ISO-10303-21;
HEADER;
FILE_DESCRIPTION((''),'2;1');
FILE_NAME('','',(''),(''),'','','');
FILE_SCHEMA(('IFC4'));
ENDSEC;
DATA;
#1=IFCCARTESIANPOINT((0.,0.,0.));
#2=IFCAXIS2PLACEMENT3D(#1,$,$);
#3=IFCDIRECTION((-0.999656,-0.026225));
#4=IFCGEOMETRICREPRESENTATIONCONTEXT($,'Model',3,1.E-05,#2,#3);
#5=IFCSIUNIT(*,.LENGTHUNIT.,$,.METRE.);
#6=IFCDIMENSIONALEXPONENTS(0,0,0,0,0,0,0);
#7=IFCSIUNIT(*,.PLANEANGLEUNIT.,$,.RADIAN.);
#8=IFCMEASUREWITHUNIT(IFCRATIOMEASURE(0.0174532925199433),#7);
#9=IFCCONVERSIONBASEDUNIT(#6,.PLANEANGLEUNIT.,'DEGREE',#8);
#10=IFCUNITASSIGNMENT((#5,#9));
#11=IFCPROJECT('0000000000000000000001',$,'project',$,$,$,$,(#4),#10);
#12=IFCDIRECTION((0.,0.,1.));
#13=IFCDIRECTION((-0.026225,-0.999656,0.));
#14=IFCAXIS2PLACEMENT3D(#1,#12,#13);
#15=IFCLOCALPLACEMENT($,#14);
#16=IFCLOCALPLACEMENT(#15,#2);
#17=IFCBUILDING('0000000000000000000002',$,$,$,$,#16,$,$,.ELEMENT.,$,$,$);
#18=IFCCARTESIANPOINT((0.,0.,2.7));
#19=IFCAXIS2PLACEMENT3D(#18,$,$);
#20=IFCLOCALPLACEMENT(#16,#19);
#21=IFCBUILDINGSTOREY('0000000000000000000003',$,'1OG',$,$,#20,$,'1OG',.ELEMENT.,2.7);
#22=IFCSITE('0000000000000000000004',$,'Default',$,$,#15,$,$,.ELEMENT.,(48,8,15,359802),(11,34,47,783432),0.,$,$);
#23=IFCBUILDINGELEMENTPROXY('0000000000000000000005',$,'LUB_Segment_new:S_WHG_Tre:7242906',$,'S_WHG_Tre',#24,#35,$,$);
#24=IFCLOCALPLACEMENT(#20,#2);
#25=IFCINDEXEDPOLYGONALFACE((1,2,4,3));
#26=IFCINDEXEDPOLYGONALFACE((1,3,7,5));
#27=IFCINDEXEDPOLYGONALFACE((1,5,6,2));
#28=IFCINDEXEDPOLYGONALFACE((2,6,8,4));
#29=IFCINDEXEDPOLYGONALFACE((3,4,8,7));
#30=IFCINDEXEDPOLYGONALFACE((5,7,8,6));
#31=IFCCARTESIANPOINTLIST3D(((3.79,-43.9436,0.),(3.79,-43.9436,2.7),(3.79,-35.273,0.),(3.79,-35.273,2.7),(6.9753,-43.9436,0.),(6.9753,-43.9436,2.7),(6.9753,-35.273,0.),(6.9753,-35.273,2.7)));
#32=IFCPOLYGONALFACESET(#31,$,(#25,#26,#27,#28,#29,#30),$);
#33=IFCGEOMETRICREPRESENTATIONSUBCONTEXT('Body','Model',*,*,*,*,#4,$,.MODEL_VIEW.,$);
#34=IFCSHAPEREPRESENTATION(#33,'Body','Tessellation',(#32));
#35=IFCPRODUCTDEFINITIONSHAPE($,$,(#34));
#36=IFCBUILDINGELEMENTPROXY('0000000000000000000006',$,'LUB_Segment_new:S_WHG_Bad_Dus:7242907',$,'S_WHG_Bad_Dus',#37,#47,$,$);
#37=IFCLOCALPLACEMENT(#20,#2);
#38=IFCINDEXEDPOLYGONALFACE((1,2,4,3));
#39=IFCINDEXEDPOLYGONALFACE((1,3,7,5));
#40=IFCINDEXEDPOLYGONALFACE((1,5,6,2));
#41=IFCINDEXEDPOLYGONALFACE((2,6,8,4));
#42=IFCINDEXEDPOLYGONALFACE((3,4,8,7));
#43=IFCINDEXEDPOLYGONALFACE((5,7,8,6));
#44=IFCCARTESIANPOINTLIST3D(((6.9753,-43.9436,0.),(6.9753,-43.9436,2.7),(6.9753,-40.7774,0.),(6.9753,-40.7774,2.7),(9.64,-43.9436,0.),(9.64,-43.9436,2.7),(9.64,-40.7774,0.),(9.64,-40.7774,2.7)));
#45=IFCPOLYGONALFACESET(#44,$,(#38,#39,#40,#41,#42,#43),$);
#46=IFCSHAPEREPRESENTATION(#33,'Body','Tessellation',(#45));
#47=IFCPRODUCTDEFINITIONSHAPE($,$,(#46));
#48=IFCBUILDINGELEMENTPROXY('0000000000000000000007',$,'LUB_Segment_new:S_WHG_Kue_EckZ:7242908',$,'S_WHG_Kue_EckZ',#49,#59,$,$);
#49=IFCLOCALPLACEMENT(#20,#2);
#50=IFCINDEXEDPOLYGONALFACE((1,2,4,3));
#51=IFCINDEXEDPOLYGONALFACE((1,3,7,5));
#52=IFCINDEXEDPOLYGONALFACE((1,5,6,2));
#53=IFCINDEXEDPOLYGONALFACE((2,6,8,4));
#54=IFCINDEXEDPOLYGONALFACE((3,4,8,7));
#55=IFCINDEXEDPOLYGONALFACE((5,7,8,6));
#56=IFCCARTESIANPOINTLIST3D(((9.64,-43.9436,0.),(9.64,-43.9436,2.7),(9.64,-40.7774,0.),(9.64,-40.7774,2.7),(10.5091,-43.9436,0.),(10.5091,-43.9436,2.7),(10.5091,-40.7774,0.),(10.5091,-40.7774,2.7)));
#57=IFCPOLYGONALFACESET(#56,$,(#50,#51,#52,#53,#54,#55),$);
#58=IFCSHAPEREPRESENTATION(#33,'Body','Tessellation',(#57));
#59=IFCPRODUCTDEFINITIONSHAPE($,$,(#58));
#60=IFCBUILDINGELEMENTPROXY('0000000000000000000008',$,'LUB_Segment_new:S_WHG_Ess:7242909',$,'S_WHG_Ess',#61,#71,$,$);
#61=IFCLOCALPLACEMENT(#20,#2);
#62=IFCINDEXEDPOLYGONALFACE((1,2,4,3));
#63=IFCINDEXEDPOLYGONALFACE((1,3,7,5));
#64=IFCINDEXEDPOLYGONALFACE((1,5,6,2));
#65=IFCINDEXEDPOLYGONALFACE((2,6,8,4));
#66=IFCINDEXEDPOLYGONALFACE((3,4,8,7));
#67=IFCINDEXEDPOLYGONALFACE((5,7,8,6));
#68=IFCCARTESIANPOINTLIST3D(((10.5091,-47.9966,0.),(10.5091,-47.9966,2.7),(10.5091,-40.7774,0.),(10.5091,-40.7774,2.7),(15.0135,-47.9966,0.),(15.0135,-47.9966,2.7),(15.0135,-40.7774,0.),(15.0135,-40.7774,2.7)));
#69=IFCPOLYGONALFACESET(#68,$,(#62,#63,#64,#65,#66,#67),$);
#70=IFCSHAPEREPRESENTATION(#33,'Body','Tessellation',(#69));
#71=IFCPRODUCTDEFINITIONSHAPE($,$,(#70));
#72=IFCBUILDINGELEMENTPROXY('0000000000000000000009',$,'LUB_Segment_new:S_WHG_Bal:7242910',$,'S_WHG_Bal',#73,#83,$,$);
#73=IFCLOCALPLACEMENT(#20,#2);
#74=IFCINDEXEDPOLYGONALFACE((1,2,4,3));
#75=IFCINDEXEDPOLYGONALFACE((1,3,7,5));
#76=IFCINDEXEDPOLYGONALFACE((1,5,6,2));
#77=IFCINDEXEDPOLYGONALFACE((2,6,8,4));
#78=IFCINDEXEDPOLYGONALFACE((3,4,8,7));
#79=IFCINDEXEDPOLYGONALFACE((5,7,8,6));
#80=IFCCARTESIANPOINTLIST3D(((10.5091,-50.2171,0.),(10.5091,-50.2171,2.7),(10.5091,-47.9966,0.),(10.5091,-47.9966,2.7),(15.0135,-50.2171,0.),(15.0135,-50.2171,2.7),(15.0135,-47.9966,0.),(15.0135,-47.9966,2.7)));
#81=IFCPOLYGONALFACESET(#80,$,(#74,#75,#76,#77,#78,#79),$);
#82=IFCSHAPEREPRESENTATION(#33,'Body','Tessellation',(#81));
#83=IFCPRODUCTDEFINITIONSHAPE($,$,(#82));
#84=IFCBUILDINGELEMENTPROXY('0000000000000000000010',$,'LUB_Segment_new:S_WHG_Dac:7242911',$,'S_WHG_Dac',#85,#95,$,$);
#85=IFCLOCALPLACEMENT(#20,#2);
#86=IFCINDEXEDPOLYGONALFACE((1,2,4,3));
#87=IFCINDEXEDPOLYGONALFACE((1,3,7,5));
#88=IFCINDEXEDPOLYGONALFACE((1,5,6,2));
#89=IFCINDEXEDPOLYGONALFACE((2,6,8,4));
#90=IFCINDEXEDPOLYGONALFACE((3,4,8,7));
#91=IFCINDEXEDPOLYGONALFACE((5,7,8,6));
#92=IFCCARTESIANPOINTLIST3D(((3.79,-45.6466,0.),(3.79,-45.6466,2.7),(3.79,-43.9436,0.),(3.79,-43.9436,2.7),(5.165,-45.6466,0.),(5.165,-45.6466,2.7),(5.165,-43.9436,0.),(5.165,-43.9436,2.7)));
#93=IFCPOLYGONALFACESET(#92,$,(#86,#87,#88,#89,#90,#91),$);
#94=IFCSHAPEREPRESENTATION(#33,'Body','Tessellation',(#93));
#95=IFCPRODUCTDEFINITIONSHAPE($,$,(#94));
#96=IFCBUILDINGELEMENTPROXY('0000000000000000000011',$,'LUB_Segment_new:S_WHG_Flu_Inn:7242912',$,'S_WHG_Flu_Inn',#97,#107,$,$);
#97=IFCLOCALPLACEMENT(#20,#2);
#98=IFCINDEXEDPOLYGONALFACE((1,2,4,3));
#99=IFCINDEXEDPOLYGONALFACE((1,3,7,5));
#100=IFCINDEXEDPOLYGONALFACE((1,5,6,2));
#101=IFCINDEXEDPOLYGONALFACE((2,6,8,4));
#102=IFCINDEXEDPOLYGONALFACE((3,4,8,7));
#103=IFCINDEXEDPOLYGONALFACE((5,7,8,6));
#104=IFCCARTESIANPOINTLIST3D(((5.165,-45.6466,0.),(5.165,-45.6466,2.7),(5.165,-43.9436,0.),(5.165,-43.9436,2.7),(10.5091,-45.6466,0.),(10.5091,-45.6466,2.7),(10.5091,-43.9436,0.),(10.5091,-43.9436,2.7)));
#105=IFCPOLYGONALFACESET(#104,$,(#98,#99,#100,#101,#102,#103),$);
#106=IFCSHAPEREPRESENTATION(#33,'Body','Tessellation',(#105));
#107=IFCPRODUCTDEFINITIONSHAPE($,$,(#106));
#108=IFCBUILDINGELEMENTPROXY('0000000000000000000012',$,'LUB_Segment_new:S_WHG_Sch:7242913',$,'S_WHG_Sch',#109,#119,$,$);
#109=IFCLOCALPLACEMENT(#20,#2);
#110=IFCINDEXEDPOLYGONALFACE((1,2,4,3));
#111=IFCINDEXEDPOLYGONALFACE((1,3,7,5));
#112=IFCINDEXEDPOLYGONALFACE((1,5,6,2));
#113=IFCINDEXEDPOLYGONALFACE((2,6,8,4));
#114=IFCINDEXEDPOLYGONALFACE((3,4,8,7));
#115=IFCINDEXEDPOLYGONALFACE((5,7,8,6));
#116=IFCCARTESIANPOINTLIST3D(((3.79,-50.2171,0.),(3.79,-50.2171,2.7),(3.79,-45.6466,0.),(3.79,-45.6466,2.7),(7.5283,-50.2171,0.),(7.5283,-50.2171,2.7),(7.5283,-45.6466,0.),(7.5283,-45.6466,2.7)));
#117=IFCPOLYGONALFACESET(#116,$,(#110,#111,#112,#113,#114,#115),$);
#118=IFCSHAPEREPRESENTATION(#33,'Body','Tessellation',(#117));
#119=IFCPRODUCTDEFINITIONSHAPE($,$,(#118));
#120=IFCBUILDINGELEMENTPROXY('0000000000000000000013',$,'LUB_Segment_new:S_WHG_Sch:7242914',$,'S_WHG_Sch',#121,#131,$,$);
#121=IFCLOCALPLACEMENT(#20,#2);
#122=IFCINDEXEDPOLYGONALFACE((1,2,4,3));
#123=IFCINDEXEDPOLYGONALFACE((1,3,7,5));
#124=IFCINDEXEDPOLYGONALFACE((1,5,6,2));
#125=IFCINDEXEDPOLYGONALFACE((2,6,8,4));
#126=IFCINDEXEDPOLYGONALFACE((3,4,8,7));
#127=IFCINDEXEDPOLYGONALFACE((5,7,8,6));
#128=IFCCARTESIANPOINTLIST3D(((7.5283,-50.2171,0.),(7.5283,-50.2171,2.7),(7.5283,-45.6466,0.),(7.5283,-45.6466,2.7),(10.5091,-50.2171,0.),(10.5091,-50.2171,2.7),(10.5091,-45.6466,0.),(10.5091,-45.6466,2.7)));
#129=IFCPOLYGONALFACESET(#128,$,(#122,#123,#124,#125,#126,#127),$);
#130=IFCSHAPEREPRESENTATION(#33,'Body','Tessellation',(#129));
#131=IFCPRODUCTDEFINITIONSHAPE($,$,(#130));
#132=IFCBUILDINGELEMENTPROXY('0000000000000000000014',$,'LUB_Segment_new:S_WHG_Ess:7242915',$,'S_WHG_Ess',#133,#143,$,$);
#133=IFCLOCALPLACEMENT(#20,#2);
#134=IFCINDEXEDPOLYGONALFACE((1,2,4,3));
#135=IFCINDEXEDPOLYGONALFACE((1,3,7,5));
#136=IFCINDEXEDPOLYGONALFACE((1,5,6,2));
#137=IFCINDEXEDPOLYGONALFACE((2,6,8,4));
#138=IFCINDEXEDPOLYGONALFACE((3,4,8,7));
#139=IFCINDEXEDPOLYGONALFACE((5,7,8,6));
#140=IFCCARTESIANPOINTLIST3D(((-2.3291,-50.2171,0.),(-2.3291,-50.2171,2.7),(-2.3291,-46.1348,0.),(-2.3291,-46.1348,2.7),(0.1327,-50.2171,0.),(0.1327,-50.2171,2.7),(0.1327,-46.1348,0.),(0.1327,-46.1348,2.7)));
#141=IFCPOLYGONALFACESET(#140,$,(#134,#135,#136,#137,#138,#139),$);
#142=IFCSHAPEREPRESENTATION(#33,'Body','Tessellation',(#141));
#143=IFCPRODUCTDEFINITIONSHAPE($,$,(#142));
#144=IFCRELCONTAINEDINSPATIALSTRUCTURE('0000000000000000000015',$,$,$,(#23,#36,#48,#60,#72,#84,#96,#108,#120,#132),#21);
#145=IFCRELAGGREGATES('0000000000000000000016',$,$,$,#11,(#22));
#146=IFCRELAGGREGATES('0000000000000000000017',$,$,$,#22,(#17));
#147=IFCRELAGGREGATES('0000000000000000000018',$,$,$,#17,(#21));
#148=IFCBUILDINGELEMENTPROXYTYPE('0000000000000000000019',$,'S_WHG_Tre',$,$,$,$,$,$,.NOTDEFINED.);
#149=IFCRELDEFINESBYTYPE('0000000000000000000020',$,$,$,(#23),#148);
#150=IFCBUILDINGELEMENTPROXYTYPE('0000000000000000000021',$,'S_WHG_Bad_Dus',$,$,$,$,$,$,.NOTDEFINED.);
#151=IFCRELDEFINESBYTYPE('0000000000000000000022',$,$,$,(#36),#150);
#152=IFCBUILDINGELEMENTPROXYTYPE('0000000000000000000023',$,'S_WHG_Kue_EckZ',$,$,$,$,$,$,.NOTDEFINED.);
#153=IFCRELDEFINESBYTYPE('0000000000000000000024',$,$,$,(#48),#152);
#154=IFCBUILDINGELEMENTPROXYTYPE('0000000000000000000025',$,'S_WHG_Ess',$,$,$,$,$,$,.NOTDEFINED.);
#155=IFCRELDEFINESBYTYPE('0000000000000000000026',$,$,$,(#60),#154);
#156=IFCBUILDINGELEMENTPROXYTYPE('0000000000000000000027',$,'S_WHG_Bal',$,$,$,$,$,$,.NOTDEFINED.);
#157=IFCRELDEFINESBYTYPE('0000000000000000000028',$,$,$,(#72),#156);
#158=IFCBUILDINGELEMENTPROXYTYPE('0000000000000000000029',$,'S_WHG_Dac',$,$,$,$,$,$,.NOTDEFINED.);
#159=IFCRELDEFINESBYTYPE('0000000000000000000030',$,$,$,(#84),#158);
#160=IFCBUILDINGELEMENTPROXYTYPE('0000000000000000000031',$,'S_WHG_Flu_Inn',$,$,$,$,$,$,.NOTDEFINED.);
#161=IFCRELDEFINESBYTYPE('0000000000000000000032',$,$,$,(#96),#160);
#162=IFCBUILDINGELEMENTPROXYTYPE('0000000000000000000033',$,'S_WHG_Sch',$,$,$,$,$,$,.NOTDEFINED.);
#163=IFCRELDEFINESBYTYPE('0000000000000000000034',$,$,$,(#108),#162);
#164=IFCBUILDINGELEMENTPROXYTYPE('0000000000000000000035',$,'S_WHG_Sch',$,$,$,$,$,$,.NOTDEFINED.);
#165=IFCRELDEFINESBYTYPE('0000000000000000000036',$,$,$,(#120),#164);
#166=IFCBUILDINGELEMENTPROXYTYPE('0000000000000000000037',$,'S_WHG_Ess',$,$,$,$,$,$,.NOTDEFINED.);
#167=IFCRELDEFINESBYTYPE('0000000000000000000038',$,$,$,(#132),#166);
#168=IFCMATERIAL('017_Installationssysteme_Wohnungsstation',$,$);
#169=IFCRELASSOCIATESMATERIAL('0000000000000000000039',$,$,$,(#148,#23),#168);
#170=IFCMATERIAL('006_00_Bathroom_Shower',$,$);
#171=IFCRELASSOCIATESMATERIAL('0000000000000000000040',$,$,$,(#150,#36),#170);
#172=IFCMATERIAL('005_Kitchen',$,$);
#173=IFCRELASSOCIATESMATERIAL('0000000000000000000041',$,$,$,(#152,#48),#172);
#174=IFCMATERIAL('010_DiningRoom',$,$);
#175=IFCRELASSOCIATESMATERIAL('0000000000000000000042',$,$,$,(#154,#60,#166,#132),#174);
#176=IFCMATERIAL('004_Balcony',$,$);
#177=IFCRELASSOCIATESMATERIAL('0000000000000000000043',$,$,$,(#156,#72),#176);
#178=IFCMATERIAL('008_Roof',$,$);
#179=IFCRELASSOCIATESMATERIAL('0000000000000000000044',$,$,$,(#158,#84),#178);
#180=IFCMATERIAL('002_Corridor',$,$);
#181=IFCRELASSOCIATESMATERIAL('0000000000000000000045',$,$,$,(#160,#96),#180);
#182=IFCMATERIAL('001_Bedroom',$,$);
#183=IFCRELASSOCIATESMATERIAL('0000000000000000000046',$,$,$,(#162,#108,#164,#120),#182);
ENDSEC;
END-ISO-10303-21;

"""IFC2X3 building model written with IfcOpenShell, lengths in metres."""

from ifc_helpers import new_model, entity, si_unit, converted_unit, direction, frame, frame_2d, origin, origin_2d_with_axis, place, context, subcontext, project, spatial, rectangle, extrude, source, transform, mapped, material, type_object, type_shapes, element, save


model = new_model("IFC2X3")

# Units and contexts
model_context = context("Model", 3, precision=1e-05, world=origin(), true_north=direction((-0.999656, -0.026225)))
body_context = subcontext(model_context, "Body", "Model", "MODEL_VIEW")
ifc_project = project(units=[si_unit("LENGTHUNIT", "METRE"), converted_unit("PLANEANGLEUNIT", "DEGREE", entity("IfcRatioMeasure", 0.0174532925199433), si_unit("PLANEANGLEUNIT", "RADIAN"), dimensions=[0, 0, 0, 0, 0, 0, 0])], contexts=[model_context])

# Site, building, storey
site_placement = place(None, frame((0.0, 0.0, 0.0), z_axis=(0.0, 0.0, 1.0), x_axis=(-0.026225, -0.999656, 0.0)))
site = spatial("IfcSite", under=ifc_project, at=site_placement, Name="Default", CompositionType="ELEMENT", RefLatitude=(48, 8, 15, 359802), RefLongitude=(11, 34, 47, 783432), RefElevation=0.0)
building_placement = place(site_placement, origin())
building = spatial("IfcBuilding", under=site, at=building_placement, CompositionType="ELEMENT")
storey_placement = place(building_placement, frame((0.0, 0.0, 2.7)))
storey = spatial("IfcBuildingStorey", under=building, at=storey_placement, Name="1OG", LongName="1OG", CompositionType="ELEMENT", Elevation=2.7)

# Building element proxies
ifc_material_1 = material(Name="001_Bedroom")
ifc_material_2 = material(Name="010_DiningRoom")
ifc_material_3 = material(Name="004_Balcony")
ifc_material_4 = material(Name="005_Kitchen")
ifc_material_5 = material(Name="002_Corridor")
ifc_material_6 = material(Name="008_Roof")
ifc_material_7 = material(Name="006_00_Bathroom_Shower")
ifc_material_8 = material(Name="017_Installationssysteme_Wohnungsstation")
building_element_proxy_type_1 = type_object("IfcBuildingElementProxyType", Name="S_WHG_Tre", PredefinedType="NOTDEFINED", material=ifc_material_8)
shared_shape_1 = source(origin(), body_context, "Body", "SweptSolid", [
    extrude(rectangle(XDim=3.1853, YDim=8.6706, at=frame_2d((0.0, 0.0), x_axis=(1.0, 0.0))), frame((0.0, 0.0, 0.0), z_axis=(0.0, 0.0, 1.0), x_axis=(-1.0, 0.0, 0.0)), (0.0, 0.0, 1.0), 2.7),
])
type_shapes(building_element_proxy_type_1, [shared_shape_1])
proxy_1_placement = place(storey_placement, frame((5.3827, -39.6083, 0.0)))
element("IfcBuildingElementProxy", 1, at=proxy_1_placement, inside=storey, type_object=building_element_proxy_type_1, material=ifc_material_8, Name="LUB_Segment_new:S_WHG_Tre:7242906", ObjectType="S_WHG_Tre", context=body_context, shape_type="MappedRepresentation", body=[
    mapped(shared_shape_1, transform((0.0, 0.0, 0.0), scale=1.0)),
])
building_element_proxy_type_2 = type_object("IfcBuildingElementProxyType", Name="S_WHG_Bad_Dus", PredefinedType="NOTDEFINED", material=ifc_material_7)
shared_shape_2 = source(origin(), body_context, "Body", "SweptSolid", [
    extrude(rectangle(XDim=3.1662, YDim=2.6647, at=origin_2d_with_axis()), frame((0.0, 0.0, 0.0), z_axis=(0.0, 0.0, 1.0), x_axis=(0.0, 1.0, 0.0)), (0.0, 0.0, 1.0), 2.7),
])
type_shapes(building_element_proxy_type_2, [shared_shape_2])
proxy_2_placement = place(storey_placement, frame((8.3077, -42.3605, 0.0)))
element("IfcBuildingElementProxy", 2, at=proxy_2_placement, inside=storey, type_object=building_element_proxy_type_2, material=ifc_material_7, Name="LUB_Segment_new:S_WHG_Bad_Dus:7242907", ObjectType="S_WHG_Bad_Dus", context=body_context, shape_type="MappedRepresentation", body=[
    mapped(shared_shape_2, transform((0.0, 0.0, 0.0), scale=1.0)),
])
building_element_proxy_type_3 = type_object("IfcBuildingElementProxyType", Name="S_WHG_Kue_EckZ", PredefinedType="NOTDEFINED", material=ifc_material_4)
shared_shape_3 = source(origin(), body_context, "Body", "SweptSolid", [
    extrude(rectangle(XDim=3.1662, YDim=0.8691, at=origin_2d_with_axis()), frame((0.0, 0.0, 0.0), z_axis=(0.0, 0.0, 1.0), x_axis=(0.0, 1.0, 0.0)), (0.0, 0.0, 1.0), 2.7),
])
type_shapes(building_element_proxy_type_3, [shared_shape_3])
proxy_3_placement = place(storey_placement, frame((10.0746, -42.3605, 0.0)))
element("IfcBuildingElementProxy", 3, at=proxy_3_placement, inside=storey, type_object=building_element_proxy_type_3, material=ifc_material_4, Name="LUB_Segment_new:S_WHG_Kue_EckZ:7242908", ObjectType="S_WHG_Kue_EckZ", context=body_context, shape_type="MappedRepresentation", body=[
    mapped(shared_shape_3, transform((0.0, 0.0, 0.0), scale=1.0)),
])
building_element_proxy_type_4 = type_object("IfcBuildingElementProxyType", Name="S_WHG_Ess", PredefinedType="NOTDEFINED", material=ifc_material_2)
shared_shape_4 = source(origin(), body_context, "Body", "SweptSolid", [
    extrude(rectangle(XDim=4.5044, YDim=7.2191, at=origin_2d_with_axis()), frame((0.0, 0.0, 0.0), z_axis=(0.0, 0.0, 1.0), x_axis=(-1.0, 0.0, 0.0)), (0.0, 0.0, 1.0), 2.7),
])
type_shapes(building_element_proxy_type_4, [shared_shape_4])
proxy_4_placement = place(storey_placement, frame((12.7613, -44.387, 0.0)))
element("IfcBuildingElementProxy", 4, at=proxy_4_placement, inside=storey, type_object=building_element_proxy_type_4, material=ifc_material_2, Name="LUB_Segment_new:S_WHG_Ess:7242909", ObjectType="S_WHG_Ess", context=body_context, shape_type="MappedRepresentation", body=[
    mapped(shared_shape_4, transform((0.0, 0.0, 0.0), scale=1.0)),
])
building_element_proxy_type_5 = type_object("IfcBuildingElementProxyType", Name="S_WHG_Bal", PredefinedType="NOTDEFINED", material=ifc_material_3)
shared_shape_5 = source(origin(), body_context, "Body", "SweptSolid", [
    extrude(rectangle(XDim=2.2206, YDim=4.5044, at=origin_2d_with_axis()), frame((0.0, 0.0, 0.0), z_axis=(0.0, 0.0, 1.0), x_axis=(0.0, 1.0, 0.0)), (0.0, 0.0, 1.0), 2.7),
])
type_shapes(building_element_proxy_type_5, [shared_shape_5])
proxy_5_placement = place(storey_placement, frame((12.7613, -49.1068, 0.0)))
element("IfcBuildingElementProxy", 5, at=proxy_5_placement, inside=storey, type_object=building_element_proxy_type_5, material=ifc_material_3, Name="LUB_Segment_new:S_WHG_Bal:7242910", ObjectType="S_WHG_Bal", context=body_context, shape_type="MappedRepresentation", body=[
    mapped(shared_shape_5, transform((0.0, 0.0, 0.0), scale=1.0)),
])
building_element_proxy_type_6 = type_object("IfcBuildingElementProxyType", Name="S_WHG_Dac", PredefinedType="NOTDEFINED", material=ifc_material_6)
shared_shape_6 = source(origin(), body_context, "Body", "SweptSolid", [
    extrude(rectangle(XDim=1.7029, YDim=1.375, at=origin_2d_with_axis()), frame((0.0, 0.0, 0.0), z_axis=(0.0, 0.0, 1.0), x_axis=(0.0, 1.0, 0.0)), (0.0, 0.0, 1.0), 2.7),
])
type_shapes(building_element_proxy_type_6, [shared_shape_6])
proxy_6_placement = place(storey_placement, frame((4.4775, -44.7951, 0.0)))
element("IfcBuildingElementProxy", 6, at=proxy_6_placement, inside=storey, type_object=building_element_proxy_type_6, material=ifc_material_6, Name="LUB_Segment_new:S_WHG_Dac:7242911", ObjectType="S_WHG_Dac", context=body_context, shape_type="MappedRepresentation", body=[
    mapped(shared_shape_6, transform((0.0, 0.0, 0.0), scale=1.0)),
])
building_element_proxy_type_7 = type_object("IfcBuildingElementProxyType", Name="S_WHG_Flu_Inn", PredefinedType="NOTDEFINED", material=ifc_material_5)
shared_shape_7 = source(origin(), body_context, "Body", "SweptSolid", [
    extrude(rectangle(XDim=1.7029, YDim=5.3441, at=origin_2d_with_axis()), frame((0.0, 0.0, 0.0), z_axis=(0.0, 0.0, 1.0), x_axis=(0.0, 1.0, 0.0)), (0.0, 0.0, 1.0), 2.7),
])
type_shapes(building_element_proxy_type_7, [shared_shape_7])
proxy_7_placement = place(storey_placement, frame((7.8371, -44.7951, 0.0)))
element("IfcBuildingElementProxy", 7, at=proxy_7_placement, inside=storey, type_object=building_element_proxy_type_7, material=ifc_material_5, Name="LUB_Segment_new:S_WHG_Flu_Inn:7242912", ObjectType="S_WHG_Flu_Inn", context=body_context, shape_type="MappedRepresentation", body=[
    mapped(shared_shape_7, transform((0.0, 0.0, 0.0), scale=1.0)),
])
building_element_proxy_type_8 = type_object("IfcBuildingElementProxyType", Name="S_WHG_Sch", PredefinedType="NOTDEFINED", material=ifc_material_1)
shared_shape_8 = source(origin(), body_context, "Body", "SweptSolid", [
    extrude(rectangle(XDim=3.7382, YDim=4.5706, at=origin_2d_with_axis()), frame((0.0, 0.0, 0.0), z_axis=(0.0, 0.0, 1.0), x_axis=(-1.0, 0.0, 0.0)), (0.0, 0.0, 1.0), 2.7),
])
type_shapes(building_element_proxy_type_8, [shared_shape_8])
proxy_8_placement = place(storey_placement, frame((5.6591, -47.9318, 0.0)))
element("IfcBuildingElementProxy", 8, at=proxy_8_placement, inside=storey, type_object=building_element_proxy_type_8, material=ifc_material_1, Name="LUB_Segment_new:S_WHG_Sch:7242913", ObjectType="S_WHG_Sch", context=body_context, shape_type="MappedRepresentation", body=[
    mapped(shared_shape_8, transform((0.0, 0.0, 0.0), scale=1.0)),
])
building_element_proxy_type_9 = type_object("IfcBuildingElementProxyType", Name="S_WHG_Sch", PredefinedType="NOTDEFINED", material=ifc_material_1)
shared_shape_9 = source(origin(), body_context, "Body", "SweptSolid", [
    extrude(rectangle(XDim=2.9809, YDim=4.5706, at=origin_2d_with_axis()), frame((0.0, 0.0, 0.0), z_axis=(0.0, 0.0, 1.0), x_axis=(-1.0, 0.0, 0.0)), (0.0, 0.0, 1.0), 2.7),
])
type_shapes(building_element_proxy_type_9, [shared_shape_9])
proxy_9_placement = place(storey_placement, frame((9.0187, -47.9318, 0.0)))
element("IfcBuildingElementProxy", 9, at=proxy_9_placement, inside=storey, type_object=building_element_proxy_type_9, material=ifc_material_1, Name="LUB_Segment_new:S_WHG_Sch:7242914", ObjectType="S_WHG_Sch", context=body_context, shape_type="MappedRepresentation", body=[
    mapped(shared_shape_9, transform((0.0, 0.0, 0.0), scale=1.0)),
])
building_element_proxy_type_10 = type_object("IfcBuildingElementProxyType", Name="S_WHG_Ess", PredefinedType="NOTDEFINED", material=ifc_material_2)
shared_shape_10 = source(origin(), body_context, "Body", "SweptSolid", [
    extrude(rectangle(XDim=4.0824, YDim=2.4618, at=origin_2d_with_axis()), frame((0.0, 0.0, 0.0), z_axis=(0.0, 0.0, 1.0), x_axis=(0.0, 1.0, 0.0)), (0.0, 0.0, 1.0), 2.7),
])
type_shapes(building_element_proxy_type_10, [shared_shape_10])
proxy_10_placement = place(storey_placement, frame((-1.0982, -48.176, 0.0)))
element("IfcBuildingElementProxy", 10, at=proxy_10_placement, inside=storey, type_object=building_element_proxy_type_10, material=ifc_material_2, Name="LUB_Segment_new:S_WHG_Ess:7242915", ObjectType="S_WHG_Ess", context=body_context, shape_type="MappedRepresentation", body=[
    mapped(shared_shape_10, transform((0.0, 0.0, 0.0), scale=1.0)),
])

save(model, "model.ifc")
